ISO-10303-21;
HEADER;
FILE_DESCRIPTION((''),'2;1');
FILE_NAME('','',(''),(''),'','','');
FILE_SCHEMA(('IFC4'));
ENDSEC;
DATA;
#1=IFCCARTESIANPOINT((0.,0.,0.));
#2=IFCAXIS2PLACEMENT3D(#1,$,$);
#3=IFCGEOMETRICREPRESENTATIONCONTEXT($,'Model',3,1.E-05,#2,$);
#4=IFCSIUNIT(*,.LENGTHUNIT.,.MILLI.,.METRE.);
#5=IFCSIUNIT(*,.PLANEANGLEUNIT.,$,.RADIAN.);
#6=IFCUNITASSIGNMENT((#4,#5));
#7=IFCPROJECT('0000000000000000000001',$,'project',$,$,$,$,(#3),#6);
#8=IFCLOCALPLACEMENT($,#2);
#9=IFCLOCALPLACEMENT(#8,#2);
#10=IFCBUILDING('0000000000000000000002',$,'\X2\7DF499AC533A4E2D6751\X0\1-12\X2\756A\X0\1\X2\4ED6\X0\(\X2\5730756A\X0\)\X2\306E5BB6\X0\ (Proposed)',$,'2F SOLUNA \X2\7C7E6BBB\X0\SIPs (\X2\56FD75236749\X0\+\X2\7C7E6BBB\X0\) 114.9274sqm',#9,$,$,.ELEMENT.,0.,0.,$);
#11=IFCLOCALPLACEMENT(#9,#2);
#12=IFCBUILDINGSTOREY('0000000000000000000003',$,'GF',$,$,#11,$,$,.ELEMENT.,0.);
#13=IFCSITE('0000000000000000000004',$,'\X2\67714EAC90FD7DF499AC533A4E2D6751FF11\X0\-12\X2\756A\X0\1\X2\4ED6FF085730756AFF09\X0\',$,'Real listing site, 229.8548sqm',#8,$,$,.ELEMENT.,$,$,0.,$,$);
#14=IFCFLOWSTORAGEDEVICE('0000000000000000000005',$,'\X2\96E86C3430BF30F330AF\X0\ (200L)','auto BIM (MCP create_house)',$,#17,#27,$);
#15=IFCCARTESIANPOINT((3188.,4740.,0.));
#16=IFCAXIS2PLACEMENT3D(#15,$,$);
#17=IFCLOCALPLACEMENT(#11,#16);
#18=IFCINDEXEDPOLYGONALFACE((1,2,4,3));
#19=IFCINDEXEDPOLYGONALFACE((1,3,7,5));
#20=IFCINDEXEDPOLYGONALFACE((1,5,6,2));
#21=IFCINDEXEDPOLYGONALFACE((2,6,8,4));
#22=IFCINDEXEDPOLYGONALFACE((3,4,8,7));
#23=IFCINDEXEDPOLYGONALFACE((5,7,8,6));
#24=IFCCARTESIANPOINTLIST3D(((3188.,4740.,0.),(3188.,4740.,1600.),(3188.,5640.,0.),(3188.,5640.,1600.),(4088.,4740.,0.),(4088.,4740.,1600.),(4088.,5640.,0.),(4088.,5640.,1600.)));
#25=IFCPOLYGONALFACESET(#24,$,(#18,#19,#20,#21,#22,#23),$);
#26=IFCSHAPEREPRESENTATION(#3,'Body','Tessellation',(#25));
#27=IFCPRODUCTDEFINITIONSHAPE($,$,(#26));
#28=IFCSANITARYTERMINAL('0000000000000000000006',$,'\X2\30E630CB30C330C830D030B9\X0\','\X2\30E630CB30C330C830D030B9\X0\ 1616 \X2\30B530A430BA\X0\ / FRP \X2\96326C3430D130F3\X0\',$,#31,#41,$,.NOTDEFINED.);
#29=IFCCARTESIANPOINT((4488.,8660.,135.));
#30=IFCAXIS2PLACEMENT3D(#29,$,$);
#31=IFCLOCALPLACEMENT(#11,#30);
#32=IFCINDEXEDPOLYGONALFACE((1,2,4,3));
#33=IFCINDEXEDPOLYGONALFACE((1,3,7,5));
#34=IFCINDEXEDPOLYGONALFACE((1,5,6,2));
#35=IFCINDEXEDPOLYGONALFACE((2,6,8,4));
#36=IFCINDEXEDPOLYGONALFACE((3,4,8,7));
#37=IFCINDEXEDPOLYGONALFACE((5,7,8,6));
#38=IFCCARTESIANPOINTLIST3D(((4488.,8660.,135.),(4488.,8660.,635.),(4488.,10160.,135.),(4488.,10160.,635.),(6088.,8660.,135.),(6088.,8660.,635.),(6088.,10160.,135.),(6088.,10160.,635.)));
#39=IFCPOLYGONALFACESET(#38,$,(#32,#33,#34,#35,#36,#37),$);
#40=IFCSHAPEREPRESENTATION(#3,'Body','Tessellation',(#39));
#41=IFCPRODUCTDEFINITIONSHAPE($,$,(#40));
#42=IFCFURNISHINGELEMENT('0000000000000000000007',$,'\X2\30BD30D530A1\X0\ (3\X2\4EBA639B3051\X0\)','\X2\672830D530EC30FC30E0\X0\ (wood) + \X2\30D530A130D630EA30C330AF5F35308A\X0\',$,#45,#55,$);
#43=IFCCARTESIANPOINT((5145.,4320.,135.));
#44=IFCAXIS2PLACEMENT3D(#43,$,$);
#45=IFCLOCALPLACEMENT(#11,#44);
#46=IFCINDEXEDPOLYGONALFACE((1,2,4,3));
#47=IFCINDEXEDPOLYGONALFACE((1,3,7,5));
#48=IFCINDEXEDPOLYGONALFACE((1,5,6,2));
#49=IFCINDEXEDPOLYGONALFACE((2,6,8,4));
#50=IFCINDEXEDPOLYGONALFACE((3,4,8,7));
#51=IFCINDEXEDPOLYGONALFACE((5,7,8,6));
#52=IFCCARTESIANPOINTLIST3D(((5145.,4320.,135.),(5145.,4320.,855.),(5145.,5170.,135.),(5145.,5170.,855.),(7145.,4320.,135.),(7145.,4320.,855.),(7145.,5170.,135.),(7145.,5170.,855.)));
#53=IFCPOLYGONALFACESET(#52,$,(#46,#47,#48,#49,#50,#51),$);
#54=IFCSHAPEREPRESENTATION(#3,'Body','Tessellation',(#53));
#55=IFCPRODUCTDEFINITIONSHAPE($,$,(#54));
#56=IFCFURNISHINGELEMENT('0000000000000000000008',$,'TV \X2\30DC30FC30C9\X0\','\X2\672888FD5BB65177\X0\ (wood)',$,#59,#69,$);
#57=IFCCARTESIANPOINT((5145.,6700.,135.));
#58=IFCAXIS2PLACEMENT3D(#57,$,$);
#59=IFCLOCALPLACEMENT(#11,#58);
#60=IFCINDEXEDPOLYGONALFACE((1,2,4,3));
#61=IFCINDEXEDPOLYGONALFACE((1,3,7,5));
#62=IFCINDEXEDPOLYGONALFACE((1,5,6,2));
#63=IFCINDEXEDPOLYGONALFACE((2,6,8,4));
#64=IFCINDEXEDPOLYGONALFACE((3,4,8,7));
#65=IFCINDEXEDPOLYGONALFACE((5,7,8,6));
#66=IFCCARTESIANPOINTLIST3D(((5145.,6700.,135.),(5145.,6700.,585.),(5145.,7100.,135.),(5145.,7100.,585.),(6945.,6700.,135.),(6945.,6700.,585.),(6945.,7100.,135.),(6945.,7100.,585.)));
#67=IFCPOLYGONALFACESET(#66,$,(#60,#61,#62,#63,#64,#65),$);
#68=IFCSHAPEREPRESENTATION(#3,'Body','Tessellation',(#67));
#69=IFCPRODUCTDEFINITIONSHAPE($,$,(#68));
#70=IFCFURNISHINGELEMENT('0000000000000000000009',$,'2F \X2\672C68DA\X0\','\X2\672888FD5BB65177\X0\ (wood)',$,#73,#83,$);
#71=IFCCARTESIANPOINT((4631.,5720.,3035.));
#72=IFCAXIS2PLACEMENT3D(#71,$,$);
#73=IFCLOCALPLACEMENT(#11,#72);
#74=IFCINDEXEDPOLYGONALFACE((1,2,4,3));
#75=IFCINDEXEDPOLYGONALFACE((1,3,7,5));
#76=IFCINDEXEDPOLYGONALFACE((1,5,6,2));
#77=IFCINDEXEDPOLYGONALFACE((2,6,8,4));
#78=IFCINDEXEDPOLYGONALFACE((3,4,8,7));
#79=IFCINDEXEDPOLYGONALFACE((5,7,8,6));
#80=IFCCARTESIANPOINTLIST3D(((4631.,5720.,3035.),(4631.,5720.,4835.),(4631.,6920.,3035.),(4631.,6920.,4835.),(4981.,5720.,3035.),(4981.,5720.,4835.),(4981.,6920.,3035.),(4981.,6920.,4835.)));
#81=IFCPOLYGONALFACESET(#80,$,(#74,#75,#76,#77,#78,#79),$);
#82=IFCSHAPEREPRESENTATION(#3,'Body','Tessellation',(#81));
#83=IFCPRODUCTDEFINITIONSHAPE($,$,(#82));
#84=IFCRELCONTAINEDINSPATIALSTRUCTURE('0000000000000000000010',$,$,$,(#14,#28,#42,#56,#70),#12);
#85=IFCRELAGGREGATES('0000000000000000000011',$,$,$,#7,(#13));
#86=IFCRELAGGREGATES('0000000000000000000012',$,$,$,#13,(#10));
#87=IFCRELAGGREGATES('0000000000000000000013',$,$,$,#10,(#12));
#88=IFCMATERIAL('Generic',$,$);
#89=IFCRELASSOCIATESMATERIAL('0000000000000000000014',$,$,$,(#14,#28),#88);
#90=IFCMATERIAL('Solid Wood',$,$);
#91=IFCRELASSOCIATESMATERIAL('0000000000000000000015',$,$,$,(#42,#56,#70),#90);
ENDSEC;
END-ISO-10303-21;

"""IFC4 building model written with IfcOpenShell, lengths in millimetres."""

from ifc_helpers import new_model, si_unit, frame, frame_2d, origin, place, context, project, spatial, rectangle, extrude, material, element, save


model = new_model("IFC4")

# Units and contexts
model_context = context("Model", 3, precision=1e-05, world=origin())
ifc_project = project(units=[si_unit("LENGTHUNIT", "METRE", prefix="MILLI"), si_unit("PLANEANGLEUNIT", "RADIAN")], contexts=[model_context])

# Site, building, storey
site_placement = place(None, origin())
site = spatial("IfcSite", under=ifc_project, at=site_placement, Name="東京都練馬区中村１-12番1他（地番）", ObjectType="Real listing site, 229.8548sqm", CompositionType="ELEMENT", RefElevation=0.0)
building_placement = place(site_placement, origin())
building = spatial("IfcBuilding", under=site, at=building_placement, Name="練馬区中村1-12番1他(地番)の家 (Proposed)", ObjectType="2F SOLUNA 籾殻SIPs (国産杉+籾殻) 114.9274sqm", CompositionType="ELEMENT", ElevationOfRefHeight=0.0, ElevationOfTerrain=0.0)
storey_placement = place(building_placement, origin())
storey = spatial("IfcBuildingStorey", under=building, at=storey_placement, Name="GF", CompositionType="ELEMENT", Elevation=0.0)

# Shared definitions
ifc_material_1 = material(Name="Solid Wood")

# Shared definitions
ifc_material_2 = material(Name="Generic")

# Flow storage device
flow_storage_device_placement = place(storey_placement, frame((3188.0, 4740.0, 0.0)))
element("IfcFlowStorageDevice", 1, at=flow_storage_device_placement, inside=storey, material=ifc_material_2, Name="雨水タンク (200L)", Description="auto BIM (MCP create_house)", context=model_context, shape_type="SweptSolid", body=[
    extrude(rectangle(XDim=900.0, YDim=900.0, at=frame_2d((450.0, 450.0))), frame((3188.0, 4740.0, 0.0)), (0.0, 0.0, 1.0), 1600.0),
])

# Sanitary terminal
sanitary_terminal_placement = place(storey_placement, frame((4488.0, 8660.0, 135.0)))
element("IfcSanitaryTerminal", 2, at=sanitary_terminal_placement, inside=storey, material=ifc_material_2, Name="ユニットバス", Description="ユニットバス 1616 サイズ / FRP 防水パン", PredefinedType="NOTDEFINED", context=model_context, shape_type="SweptSolid", body=[
    extrude(rectangle(XDim=1600.0, YDim=1500.0, at=frame_2d((800.0, 750.0))), frame((4488.0, 8660.0, 135.0)), (0.0, 0.0, 1.0), 500.0),
])

# Furnishing elements
furnishing_1_placement = place(storey_placement, frame((5145.0, 4320.0, 135.0)))
element("IfcFurnishingElement", 3, at=furnishing_1_placement, inside=storey, material=ifc_material_1, Name="ソファ (3人掛け)", Description="木フレーム (wood) + ファブリック張り", context=model_context, shape_type="SweptSolid", body=[
    extrude(rectangle(XDim=2000.0, YDim=850.0, at=frame_2d((1000.0, 425.0))), frame((5145.0, 4320.0, 135.0)), (0.0, 0.0, 1.0), 720.0),
])
furnishing_2_placement = place(storey_placement, frame((5145.0, 6700.0, 135.0)))
element("IfcFurnishingElement", 4, at=furnishing_2_placement, inside=storey, material=ifc_material_1, Name="TV ボード", Description="木製家具 (wood)", context=model_context, shape_type="SweptSolid", body=[
    extrude(rectangle(XDim=1800.0, YDim=400.0, at=frame_2d((900.0, 200.0))), frame((5145.0, 6700.0, 135.0)), (0.0, 0.0, 1.0), 450.0),
])
furnishing_3_placement = place(storey_placement, frame((4631.0, 5720.0, 3035.0)))
element("IfcFurnishingElement", 5, at=furnishing_3_placement, inside=storey, material=ifc_material_1, Name="2F 本棚", Description="木製家具 (wood)", context=model_context, shape_type="SweptSolid", body=[
    extrude(rectangle(XDim=350.0, YDim=1200.0, at=frame_2d((175.0, 600.0))), frame((4631.0, 5720.0, 3035.0)), (0.0, 0.0, 1.0), 1800.0),
])

save(model, "model.ifc")
